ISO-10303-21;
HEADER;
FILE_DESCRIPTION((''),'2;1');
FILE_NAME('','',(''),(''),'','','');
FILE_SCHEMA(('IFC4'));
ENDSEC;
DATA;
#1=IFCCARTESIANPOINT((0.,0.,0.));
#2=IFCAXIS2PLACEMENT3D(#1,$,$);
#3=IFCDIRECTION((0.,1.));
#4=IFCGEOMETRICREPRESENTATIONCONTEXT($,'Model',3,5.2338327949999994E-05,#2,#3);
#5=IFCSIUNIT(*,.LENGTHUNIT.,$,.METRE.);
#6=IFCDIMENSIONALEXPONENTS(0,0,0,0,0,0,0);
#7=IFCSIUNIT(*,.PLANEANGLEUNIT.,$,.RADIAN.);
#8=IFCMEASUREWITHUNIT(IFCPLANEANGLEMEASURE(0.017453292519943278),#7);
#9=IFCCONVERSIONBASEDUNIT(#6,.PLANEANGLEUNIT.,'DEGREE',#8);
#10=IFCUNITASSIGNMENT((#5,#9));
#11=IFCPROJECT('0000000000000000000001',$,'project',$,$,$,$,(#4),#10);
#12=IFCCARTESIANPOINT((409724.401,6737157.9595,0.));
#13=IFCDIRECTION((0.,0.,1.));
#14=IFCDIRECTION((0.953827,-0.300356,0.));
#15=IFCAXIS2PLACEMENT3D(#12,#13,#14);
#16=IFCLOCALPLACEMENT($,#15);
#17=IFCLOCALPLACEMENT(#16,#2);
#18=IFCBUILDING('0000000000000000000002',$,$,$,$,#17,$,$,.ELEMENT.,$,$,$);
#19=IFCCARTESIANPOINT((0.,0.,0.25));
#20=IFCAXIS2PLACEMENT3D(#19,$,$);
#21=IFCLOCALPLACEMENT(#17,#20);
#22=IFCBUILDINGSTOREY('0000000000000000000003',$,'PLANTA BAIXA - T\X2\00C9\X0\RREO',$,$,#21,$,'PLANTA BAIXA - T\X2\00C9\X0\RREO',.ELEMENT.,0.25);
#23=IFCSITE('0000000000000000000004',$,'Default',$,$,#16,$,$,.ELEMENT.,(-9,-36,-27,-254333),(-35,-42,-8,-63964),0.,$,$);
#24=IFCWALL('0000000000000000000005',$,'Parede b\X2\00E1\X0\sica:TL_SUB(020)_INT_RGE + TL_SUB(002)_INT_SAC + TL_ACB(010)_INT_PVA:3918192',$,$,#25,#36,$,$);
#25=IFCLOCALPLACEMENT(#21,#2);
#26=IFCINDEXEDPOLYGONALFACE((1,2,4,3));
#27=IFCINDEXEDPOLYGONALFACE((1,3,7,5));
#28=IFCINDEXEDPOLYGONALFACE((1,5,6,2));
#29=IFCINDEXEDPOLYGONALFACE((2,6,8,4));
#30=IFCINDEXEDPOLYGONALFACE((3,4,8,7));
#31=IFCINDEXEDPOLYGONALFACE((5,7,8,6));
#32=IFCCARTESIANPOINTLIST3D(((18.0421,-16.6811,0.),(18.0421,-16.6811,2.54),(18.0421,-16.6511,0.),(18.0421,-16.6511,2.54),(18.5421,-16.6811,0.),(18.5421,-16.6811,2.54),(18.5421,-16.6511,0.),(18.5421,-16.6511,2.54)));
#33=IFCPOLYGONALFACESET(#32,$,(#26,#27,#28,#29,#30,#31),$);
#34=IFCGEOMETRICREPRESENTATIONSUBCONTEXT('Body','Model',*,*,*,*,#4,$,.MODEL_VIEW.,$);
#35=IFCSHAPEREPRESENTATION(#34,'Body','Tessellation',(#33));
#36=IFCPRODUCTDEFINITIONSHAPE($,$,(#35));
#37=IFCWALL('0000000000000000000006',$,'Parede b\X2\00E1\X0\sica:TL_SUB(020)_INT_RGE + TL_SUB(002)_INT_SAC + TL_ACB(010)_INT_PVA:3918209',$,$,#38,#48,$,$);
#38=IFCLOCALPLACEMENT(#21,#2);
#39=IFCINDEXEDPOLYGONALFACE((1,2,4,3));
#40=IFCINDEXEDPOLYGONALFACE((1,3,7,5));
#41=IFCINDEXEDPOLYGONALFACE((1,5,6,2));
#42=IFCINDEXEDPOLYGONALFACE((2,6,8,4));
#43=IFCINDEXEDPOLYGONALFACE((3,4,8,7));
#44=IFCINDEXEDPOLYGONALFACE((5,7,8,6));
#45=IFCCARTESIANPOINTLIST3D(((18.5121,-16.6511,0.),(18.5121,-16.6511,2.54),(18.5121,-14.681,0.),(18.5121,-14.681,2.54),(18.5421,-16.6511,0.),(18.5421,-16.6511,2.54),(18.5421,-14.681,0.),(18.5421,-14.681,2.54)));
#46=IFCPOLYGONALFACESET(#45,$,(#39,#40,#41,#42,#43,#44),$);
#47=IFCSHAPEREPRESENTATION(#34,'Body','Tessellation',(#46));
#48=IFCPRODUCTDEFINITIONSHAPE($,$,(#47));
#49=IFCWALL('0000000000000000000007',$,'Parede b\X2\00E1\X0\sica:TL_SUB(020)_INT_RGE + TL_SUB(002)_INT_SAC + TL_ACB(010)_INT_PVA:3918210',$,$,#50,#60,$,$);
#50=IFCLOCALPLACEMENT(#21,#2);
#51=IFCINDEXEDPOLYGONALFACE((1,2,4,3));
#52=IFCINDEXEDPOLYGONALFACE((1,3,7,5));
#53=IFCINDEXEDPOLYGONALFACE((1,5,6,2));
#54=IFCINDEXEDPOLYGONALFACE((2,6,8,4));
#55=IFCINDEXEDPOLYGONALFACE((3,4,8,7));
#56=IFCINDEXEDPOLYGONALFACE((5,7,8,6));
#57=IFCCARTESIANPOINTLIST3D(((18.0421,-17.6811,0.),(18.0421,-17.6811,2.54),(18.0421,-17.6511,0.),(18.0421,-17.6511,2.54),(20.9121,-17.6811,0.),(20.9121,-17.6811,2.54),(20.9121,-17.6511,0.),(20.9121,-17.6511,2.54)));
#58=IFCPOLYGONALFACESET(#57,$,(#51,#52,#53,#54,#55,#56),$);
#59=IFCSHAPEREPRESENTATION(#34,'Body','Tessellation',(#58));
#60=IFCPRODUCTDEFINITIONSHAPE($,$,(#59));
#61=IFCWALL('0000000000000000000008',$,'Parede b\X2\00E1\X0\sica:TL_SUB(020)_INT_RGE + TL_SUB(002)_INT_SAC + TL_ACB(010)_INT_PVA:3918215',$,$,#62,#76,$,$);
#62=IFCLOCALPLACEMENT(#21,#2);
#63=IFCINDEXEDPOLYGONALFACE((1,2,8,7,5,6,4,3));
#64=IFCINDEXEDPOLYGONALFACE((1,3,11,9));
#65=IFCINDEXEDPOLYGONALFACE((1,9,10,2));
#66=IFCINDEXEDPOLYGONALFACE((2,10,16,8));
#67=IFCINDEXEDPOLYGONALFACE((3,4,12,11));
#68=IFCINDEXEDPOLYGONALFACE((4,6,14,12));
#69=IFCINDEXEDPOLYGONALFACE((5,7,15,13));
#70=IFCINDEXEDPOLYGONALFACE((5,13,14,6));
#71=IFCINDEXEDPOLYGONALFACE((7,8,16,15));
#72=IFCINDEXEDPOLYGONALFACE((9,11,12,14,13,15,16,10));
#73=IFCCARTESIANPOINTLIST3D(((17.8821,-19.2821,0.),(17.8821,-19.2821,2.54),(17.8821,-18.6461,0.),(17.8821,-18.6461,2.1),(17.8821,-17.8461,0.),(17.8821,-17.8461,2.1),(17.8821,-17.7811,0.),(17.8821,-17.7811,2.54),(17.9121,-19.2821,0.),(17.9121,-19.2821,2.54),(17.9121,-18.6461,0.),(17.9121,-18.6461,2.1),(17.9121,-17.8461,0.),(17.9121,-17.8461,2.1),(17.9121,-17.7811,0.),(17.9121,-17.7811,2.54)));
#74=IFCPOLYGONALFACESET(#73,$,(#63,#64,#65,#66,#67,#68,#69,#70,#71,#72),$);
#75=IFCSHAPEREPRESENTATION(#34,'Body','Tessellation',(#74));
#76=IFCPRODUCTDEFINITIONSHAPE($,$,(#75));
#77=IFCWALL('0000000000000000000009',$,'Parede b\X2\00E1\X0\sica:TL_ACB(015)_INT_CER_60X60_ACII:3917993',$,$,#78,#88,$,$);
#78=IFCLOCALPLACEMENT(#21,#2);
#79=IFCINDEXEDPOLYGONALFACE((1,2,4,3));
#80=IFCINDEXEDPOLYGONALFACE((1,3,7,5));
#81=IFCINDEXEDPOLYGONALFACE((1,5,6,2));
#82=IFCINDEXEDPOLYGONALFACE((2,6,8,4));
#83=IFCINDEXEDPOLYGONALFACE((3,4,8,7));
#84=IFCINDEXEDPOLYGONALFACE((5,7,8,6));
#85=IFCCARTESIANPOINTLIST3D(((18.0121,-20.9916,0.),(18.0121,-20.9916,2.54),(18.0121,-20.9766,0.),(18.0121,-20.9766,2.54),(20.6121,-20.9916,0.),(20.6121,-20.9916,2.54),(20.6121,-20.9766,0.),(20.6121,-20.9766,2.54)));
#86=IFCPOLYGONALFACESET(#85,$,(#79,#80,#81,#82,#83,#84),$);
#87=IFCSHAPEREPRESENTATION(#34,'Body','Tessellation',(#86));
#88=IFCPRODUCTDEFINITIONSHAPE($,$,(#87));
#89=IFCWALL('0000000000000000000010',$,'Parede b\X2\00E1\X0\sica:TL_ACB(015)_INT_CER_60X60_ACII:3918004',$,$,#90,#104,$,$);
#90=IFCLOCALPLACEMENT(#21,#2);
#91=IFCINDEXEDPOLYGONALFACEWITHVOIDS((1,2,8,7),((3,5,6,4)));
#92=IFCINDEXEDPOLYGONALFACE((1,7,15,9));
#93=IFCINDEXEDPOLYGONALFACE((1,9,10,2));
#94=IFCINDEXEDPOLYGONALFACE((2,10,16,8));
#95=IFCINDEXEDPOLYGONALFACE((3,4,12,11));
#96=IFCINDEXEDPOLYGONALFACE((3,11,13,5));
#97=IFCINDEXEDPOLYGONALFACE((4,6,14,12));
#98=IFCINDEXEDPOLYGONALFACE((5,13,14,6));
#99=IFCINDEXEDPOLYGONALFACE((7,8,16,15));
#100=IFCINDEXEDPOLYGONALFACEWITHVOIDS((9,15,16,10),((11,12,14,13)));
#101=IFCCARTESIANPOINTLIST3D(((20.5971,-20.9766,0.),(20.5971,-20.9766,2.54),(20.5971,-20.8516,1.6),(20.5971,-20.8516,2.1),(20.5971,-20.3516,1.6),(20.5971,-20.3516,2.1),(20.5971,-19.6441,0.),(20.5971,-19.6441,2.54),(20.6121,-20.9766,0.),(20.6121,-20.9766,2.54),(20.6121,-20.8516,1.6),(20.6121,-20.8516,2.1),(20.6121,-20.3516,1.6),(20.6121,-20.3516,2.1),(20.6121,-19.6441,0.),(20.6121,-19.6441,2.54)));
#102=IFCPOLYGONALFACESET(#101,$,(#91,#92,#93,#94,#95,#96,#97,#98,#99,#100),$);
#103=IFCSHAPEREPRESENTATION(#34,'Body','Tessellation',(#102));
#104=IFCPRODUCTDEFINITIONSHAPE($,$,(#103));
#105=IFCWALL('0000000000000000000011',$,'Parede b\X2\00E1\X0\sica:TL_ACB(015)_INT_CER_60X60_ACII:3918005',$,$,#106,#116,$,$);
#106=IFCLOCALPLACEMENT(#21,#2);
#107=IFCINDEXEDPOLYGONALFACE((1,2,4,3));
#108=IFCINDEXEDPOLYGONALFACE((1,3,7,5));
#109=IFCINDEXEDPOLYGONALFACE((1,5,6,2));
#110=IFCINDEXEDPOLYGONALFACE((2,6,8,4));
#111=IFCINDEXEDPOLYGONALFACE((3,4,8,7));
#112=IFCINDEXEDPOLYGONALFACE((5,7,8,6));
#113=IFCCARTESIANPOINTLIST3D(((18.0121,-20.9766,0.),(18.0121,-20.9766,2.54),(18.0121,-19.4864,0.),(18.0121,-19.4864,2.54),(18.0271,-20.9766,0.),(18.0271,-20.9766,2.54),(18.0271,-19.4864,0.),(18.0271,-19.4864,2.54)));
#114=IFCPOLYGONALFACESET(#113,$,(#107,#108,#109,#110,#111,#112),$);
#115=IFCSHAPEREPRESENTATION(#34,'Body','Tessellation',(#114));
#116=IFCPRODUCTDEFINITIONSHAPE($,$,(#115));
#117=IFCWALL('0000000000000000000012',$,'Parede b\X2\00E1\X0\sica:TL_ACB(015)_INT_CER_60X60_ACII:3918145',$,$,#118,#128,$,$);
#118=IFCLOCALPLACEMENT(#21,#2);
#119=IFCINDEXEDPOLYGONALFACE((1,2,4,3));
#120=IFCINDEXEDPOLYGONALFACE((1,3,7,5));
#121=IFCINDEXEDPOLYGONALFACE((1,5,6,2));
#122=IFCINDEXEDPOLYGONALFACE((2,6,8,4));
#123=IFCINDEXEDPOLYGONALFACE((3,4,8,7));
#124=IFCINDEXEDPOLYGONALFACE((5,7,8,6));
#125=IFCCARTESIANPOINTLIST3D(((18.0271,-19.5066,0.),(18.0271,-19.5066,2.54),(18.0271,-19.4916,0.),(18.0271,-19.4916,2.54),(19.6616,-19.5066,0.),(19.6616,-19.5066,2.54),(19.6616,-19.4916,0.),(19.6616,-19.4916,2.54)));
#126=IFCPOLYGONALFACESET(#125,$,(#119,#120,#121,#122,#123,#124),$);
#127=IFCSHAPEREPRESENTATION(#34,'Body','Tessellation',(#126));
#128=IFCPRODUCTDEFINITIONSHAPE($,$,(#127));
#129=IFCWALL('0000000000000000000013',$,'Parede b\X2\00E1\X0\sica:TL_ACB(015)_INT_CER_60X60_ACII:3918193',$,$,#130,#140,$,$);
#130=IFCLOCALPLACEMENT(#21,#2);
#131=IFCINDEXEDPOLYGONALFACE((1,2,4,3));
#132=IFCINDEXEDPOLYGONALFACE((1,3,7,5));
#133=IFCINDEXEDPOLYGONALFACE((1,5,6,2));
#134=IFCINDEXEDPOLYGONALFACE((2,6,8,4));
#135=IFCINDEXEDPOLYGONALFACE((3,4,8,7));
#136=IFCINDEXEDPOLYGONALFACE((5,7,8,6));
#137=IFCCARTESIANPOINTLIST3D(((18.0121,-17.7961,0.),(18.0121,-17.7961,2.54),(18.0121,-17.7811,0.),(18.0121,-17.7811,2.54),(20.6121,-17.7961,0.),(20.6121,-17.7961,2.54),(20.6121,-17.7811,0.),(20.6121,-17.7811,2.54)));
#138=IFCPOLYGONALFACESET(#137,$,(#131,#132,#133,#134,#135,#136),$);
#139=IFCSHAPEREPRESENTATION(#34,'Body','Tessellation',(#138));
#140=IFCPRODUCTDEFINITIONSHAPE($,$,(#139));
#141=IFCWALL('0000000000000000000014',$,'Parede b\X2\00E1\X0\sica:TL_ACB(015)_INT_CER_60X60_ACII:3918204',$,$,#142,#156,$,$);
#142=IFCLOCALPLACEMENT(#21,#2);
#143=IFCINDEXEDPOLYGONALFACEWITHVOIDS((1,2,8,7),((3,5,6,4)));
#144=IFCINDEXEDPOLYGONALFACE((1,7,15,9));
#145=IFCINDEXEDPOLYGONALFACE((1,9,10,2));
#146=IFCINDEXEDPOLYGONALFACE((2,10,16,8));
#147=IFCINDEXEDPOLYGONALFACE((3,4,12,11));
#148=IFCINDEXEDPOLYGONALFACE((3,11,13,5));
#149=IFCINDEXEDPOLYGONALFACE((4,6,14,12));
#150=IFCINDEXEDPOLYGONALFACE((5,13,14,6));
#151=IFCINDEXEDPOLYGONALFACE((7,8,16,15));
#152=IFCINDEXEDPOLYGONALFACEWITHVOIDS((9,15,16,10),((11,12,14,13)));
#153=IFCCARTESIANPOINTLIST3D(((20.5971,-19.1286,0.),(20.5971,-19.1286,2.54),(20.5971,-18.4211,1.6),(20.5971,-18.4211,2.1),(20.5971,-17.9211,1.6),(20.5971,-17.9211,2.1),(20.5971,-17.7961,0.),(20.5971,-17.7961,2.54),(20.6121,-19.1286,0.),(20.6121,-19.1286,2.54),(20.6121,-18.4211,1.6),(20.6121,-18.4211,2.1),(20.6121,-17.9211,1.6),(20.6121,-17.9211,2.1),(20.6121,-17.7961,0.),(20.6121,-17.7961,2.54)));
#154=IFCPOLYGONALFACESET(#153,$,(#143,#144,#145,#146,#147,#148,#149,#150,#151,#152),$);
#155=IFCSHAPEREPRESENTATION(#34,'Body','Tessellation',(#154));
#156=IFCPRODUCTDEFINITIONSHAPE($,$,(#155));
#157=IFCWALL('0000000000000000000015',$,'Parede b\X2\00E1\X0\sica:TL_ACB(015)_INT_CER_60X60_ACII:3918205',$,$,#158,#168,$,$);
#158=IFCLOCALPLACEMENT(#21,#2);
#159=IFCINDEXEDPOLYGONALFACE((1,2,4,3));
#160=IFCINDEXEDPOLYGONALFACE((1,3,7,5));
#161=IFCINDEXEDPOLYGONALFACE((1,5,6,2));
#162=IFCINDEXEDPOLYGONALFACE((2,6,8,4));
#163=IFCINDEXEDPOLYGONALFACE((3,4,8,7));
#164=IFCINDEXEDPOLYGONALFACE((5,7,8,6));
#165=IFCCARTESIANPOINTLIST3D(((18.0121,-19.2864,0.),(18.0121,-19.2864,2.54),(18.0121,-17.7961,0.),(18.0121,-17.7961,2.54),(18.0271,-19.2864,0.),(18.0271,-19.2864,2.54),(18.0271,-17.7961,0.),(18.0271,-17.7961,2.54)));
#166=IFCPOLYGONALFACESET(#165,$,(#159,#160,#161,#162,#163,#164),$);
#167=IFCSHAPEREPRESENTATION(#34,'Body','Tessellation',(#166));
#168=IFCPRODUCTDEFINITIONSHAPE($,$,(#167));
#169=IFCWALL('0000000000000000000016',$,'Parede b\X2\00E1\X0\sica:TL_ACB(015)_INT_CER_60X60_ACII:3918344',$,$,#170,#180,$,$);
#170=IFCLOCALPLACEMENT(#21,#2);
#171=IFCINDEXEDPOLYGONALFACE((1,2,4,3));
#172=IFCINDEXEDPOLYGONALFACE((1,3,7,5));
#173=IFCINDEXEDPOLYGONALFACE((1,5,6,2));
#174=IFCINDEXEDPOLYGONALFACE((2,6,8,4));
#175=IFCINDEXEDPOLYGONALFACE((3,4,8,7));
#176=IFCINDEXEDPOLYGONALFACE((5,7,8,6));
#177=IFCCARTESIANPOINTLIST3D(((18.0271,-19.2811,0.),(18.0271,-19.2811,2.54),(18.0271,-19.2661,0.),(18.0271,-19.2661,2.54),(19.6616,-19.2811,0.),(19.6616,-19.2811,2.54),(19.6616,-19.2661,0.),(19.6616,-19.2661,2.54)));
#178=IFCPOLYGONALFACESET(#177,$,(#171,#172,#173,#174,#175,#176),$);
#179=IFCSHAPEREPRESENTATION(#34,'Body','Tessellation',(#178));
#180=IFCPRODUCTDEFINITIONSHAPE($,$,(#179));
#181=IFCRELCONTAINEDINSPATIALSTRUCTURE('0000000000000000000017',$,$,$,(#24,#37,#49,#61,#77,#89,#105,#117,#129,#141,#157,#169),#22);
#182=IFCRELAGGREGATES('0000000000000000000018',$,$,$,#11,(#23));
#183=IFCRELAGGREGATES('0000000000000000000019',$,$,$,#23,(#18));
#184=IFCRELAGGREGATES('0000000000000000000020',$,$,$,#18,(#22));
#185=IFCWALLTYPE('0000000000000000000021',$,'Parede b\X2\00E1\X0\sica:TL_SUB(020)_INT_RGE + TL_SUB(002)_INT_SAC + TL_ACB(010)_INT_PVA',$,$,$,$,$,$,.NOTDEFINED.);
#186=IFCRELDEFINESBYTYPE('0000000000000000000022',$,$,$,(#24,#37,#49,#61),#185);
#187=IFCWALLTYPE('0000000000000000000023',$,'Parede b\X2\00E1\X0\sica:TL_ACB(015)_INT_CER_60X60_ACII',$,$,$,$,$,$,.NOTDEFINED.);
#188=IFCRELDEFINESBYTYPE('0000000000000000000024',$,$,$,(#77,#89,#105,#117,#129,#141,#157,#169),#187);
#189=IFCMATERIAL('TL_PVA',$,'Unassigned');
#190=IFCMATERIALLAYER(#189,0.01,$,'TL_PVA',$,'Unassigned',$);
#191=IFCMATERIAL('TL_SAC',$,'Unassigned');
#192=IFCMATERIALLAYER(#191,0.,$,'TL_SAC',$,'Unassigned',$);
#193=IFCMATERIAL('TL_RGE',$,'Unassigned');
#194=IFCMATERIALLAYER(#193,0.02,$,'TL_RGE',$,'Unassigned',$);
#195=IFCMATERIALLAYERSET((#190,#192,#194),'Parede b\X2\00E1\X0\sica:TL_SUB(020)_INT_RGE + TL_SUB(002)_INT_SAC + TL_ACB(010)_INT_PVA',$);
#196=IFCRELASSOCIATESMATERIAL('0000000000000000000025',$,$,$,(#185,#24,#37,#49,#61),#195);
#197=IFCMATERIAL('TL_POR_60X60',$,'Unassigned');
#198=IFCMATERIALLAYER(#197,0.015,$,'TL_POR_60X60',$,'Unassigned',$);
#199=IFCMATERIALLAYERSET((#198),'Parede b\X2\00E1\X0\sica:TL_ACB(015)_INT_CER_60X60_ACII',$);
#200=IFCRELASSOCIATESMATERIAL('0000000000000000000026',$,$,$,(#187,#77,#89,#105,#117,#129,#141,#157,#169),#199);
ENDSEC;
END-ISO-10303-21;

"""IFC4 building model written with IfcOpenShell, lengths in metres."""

from ifc_helpers import new_model, entity, si_unit, converted_unit, direction, frame, frame_2d, origin, place, context, subcontext, project, spatial, rectangle, extrude, material, layer, layer_set, layer_usage, type_object, element, save


model = new_model("IFC4")

# Units and contexts
model_context = context("Model", 3, precision=5.2338327949999994e-05, world=origin(), true_north=direction((0.0, 1.0)))
body_context = subcontext(model_context, "Body", "Model", "MODEL_VIEW")
ifc_project = project(units=[si_unit("LENGTHUNIT", "METRE"), converted_unit("PLANEANGLEUNIT", "DEGREE", entity("IfcPlaneAngleMeasure", 0.017453292519943278), si_unit("PLANEANGLEUNIT", "RADIAN"), dimensions=[0, 0, 0, 0, 0, 0, 0])], contexts=[model_context])

# Site, building, storey
site_placement = place(None, frame((409724.401, 6737157.9595, 0.0), z_axis=(0.0, 0.0, 1.0), x_axis=(0.953827, -0.300356, 0.0)))
site = spatial("IfcSite", under=ifc_project, at=site_placement, Name="Default", CompositionType="ELEMENT", RefLatitude=(-9, -36, -27, -254333), RefLongitude=(-35, -42, -8, -63964), RefElevation=0.0)
building_placement = place(site_placement, origin())
building = spatial("IfcBuilding", under=site, at=building_placement, CompositionType="ELEMENT")
storey_placement = place(building_placement, frame((0.0, 0.0, 0.25)))
storey = spatial("IfcBuildingStorey", under=building, at=storey_placement, Name="PLANTA BAIXA - TÉRREO", LongName="PLANTA BAIXA - TÉRREO", CompositionType="ELEMENT", Elevation=0.25)

# Shared definitions
ifc_material_1 = material(Name="TL_PVA", Category="Unassigned")
ifc_layer_1 = layer(ifc_material_1, 0.01, Name="TL_PVA", Category="Unassigned")
ifc_material_2 = material(Name="TL_SAC", Category="Unassigned")
ifc_layer_2 = layer(ifc_material_2, 0.0, Name="TL_SAC", Category="Unassigned")
ifc_material_3 = material(Name="TL_RGE", Category="Unassigned")
ifc_layer_3 = layer(ifc_material_3, 0.02, Name="TL_RGE", Category="Unassigned")
ifc_layer_set_1 = layer_set([ifc_layer_1, ifc_layer_2, ifc_layer_3], Name="Parede básica:TL_SUB(020)_INT_RGE + TL_SUB(002)_INT_SAC + TL_ACB(010)_INT_PVA")
wall_type_1 = type_object("IfcWallType", Name="Parede básica:TL_SUB(020)_INT_RGE + TL_SUB(002)_INT_SAC + TL_ACB(010)_INT_PVA", PredefinedType="NOTDEFINED", material=ifc_layer_set_1)

# Walls
ifc_layer_usage_1 = layer_usage(ifc_layer_set_1, "AXIS2", "NEGATIVE", 0.015)
wall_1_placement = place(storey_placement, frame((18.5421, -16.6661, 0.0), z_axis=(0.0, 0.0, 1.0), x_axis=(-1.0, 0.0, 0.0)))
element("IfcWall", 1, at=wall_1_placement, inside=storey, type_object=wall_type_1, material=ifc_layer_usage_1, Name="Parede básica:TL_SUB(020)_INT_RGE + TL_SUB(002)_INT_SAC + TL_ACB(010)_INT_PVA:3918192", context=body_context, shape_type="SweptSolid", body=[
    extrude(rectangle(XDim=0.5, YDim=0.03, at=frame_2d((0.25, 0.0), x_axis=(-1.0, 0.0))), origin(), (0.0, 0.0, 1.0), 2.54),
])
ifc_layer_usage_2 = layer_usage(ifc_layer_set_1, "AXIS2", "POSITIVE", -0.015)
wall_2_placement = place(storey_placement, frame((18.5271, -16.6511, 0.0), z_axis=(0.0, 0.0, 1.0), x_axis=(0.0, 1.0, 0.0)))
element("IfcWall", 2, at=wall_2_placement, inside=storey, type_object=wall_type_1, material=ifc_layer_usage_2, Name="Parede básica:TL_SUB(020)_INT_RGE + TL_SUB(002)_INT_SAC + TL_ACB(010)_INT_PVA:3918209", context=body_context, shape_type="SweptSolid", body=[
    extrude(rectangle(XDim=1.9701, YDim=0.03, at=frame_2d((0.9851, 0.0), x_axis=(-1.0, 0.0))), origin(), (0.0, 0.0, 1.0), 2.54),
])
ifc_layer_usage_3 = layer_usage(ifc_layer_set_1, "AXIS2", "POSITIVE", -0.015)
wall_3_placement = place(storey_placement, frame((20.9121, -17.6661, 0.0), z_axis=(0.0, 0.0, 1.0), x_axis=(-1.0, 0.0, 0.0)))
element("IfcWall", 3, at=wall_3_placement, inside=storey, type_object=wall_type_1, material=ifc_layer_usage_3, Name="Parede básica:TL_SUB(020)_INT_RGE + TL_SUB(002)_INT_SAC + TL_ACB(010)_INT_PVA:3918210", context=body_context, shape_type="SweptSolid", body=[
    extrude(rectangle(XDim=2.87, YDim=0.03, at=frame_2d((1.435, 0.0), x_axis=(-1.0, 0.0))), origin(), (0.0, 0.0, 1.0), 2.54),
])

# Wall, opening
ifc_layer_usage_4 = layer_usage(ifc_layer_set_1, "AXIS2", "POSITIVE", -0.015)
wall_4_placement = place(storey_placement, frame((17.8971, -17.7811, 0.0), z_axis=(0.0, 0.0, 1.0), x_axis=(0.0, -1.0, 0.0)))
wall_4 = element("IfcWall", 4, at=wall_4_placement, inside=storey, type_object=wall_type_1, material=ifc_layer_usage_4, Name="Parede básica:TL_SUB(020)_INT_RGE + TL_SUB(002)_INT_SAC + TL_ACB(010)_INT_PVA:3918215", context=body_context, shape_type="SweptSolid", body=[
    extrude(rectangle(XDim=1.501, YDim=0.03, at=frame_2d((0.7505, 0.0), x_axis=(-1.0, 0.0))), origin(), (0.0, 0.0, 1.0), 2.54),
])
opening_1_placement = place(wall_4_placement, frame((0.065, -0.015, 0.0)))
element("IfcOpeningElement", 5, at=opening_1_placement, cuts=wall_4, PredefinedType="OPENING", context=body_context, shape_type="SweptSolid", body=[
    extrude(rectangle(XDim=2.1, YDim=0.8, at=frame_2d((1.05, 0.4), x_axis=(1.0, 0.0))), frame((0.0, 0.0, 0.0), z_axis=(0.0, 1.0, 0.0), x_axis=(0.0, 0.0, 1.0)), (0.0, 0.0, 1.0), 0.03),
])

# Wall
ifc_material_4 = material(Name="TL_POR_60X60", Category="Unassigned")
ifc_layer_4 = layer(ifc_material_4, 0.015, Name="TL_POR_60X60", Category="Unassigned")
ifc_layer_set_2 = layer_set([ifc_layer_4], Name="Parede básica:TL_ACB(015)_INT_CER_60X60_ACII")
ifc_layer_usage_5 = layer_usage(ifc_layer_set_2, "AXIS2", "POSITIVE", -0.0075)
wall_type_2 = type_object("IfcWallType", Name="Parede básica:TL_ACB(015)_INT_CER_60X60_ACII", PredefinedType="NOTDEFINED", material=ifc_layer_set_2)
wall_5_placement = place(storey_placement, frame((20.6121, -20.9841, 0.0), z_axis=(0.0, 0.0, 1.0), x_axis=(-1.0, 0.0, 0.0)))
element("IfcWall", 6, at=wall_5_placement, inside=storey, type_object=wall_type_2, material=ifc_layer_usage_5, Name="Parede básica:TL_ACB(015)_INT_CER_60X60_ACII:3917993", context=body_context, shape_type="SweptSolid", body=[
    extrude(rectangle(XDim=2.6, YDim=0.015, at=frame_2d((1.3, 0.0), x_axis=(-1.0, 0.0))), origin(), (0.0, 0.0, 1.0), 2.54),
])

# Wall, opening
ifc_layer_usage_6 = layer_usage(ifc_layer_set_2, "AXIS2", "NEGATIVE", 0.0075)
wall_6_placement = place(storey_placement, frame((20.6046, -20.9766, 0.0), z_axis=(0.0, 0.0, 1.0), x_axis=(0.0, 1.0, 0.0)))
wall_6 = element("IfcWall", 7, at=wall_6_placement, inside=storey, type_object=wall_type_2, material=ifc_layer_usage_6, Name="Parede básica:TL_ACB(015)_INT_CER_60X60_ACII:3918004", context=body_context, shape_type="SweptSolid", body=[
    extrude(rectangle(XDim=1.3325, YDim=0.015, at=frame_2d((0.6662, 0.0), x_axis=(-1.0, 0.0))), origin(), (0.0, 0.0, 1.0), 2.54),
])
opening_2_placement = place(wall_6_placement, frame((20.9766, 20.6046, 1.6)))
element("IfcOpeningElement", 8, at=opening_2_placement, cuts=wall_6, PredefinedType="OPENING", context=body_context, shape_type="SweptSolid", body=[
    extrude(rectangle(XDim=0.5, YDim=0.5, at=frame_2d((0.0, 0.0), x_axis=(1.0, 0.0))), frame((-20.6016, -22.2361, 0.25), z_axis=(0.0, 1.0, 0.0), x_axis=(0.0, 0.0, 1.0)), (0.0, 0.0, 1.0), 3.048),
])

# Walls
ifc_layer_usage_7 = layer_usage(ifc_layer_set_2, "AXIS2", "NEGATIVE", 0.0075)
wall_7_placement = place(storey_placement, frame((18.0196, -19.4864, 0.0), z_axis=(0.0, 0.0, 1.0), x_axis=(0.0, -1.0, 0.0)))
element("IfcWall", 9, at=wall_7_placement, inside=storey, type_object=wall_type_2, material=ifc_layer_usage_7, Name="Parede básica:TL_ACB(015)_INT_CER_60X60_ACII:3918005", context=body_context, shape_type="SweptSolid", body=[
    extrude(rectangle(XDim=1.4902, YDim=0.015, at=frame_2d((0.7451, 0.0), x_axis=(-1.0, 0.0))), origin(), (0.0, 0.0, 1.0), 2.54),
])
ifc_layer_usage_8 = layer_usage(ifc_layer_set_2, "AXIS2", "POSITIVE", -0.0075)
wall_8_placement = place(storey_placement, frame((18.0271, -19.4991, 0.0)))
element("IfcWall", 10, at=wall_8_placement, inside=storey, type_object=wall_type_2, material=ifc_layer_usage_8, Name="Parede básica:TL_ACB(015)_INT_CER_60X60_ACII:3918145", context=body_context, shape_type="SweptSolid", body=[
    extrude(rectangle(XDim=1.6345, YDim=0.015, at=frame_2d((0.8172, 0.0), x_axis=(-1.0, 0.0))), origin(), (0.0, 0.0, 1.0), 2.54),
])
ifc_layer_usage_9 = layer_usage(ifc_layer_set_2, "AXIS2", "NEGATIVE", 0.0075)
wall_9_placement = place(storey_placement, frame((20.6121, -17.7886, 0.0), z_axis=(0.0, 0.0, 1.0), x_axis=(-1.0, 0.0, 0.0)))
element("IfcWall", 11, at=wall_9_placement, inside=storey, type_object=wall_type_2, material=ifc_layer_usage_9, Name="Parede básica:TL_ACB(015)_INT_CER_60X60_ACII:3918193", context=body_context, shape_type="SweptSolid", body=[
    extrude(rectangle(XDim=2.6, YDim=0.015, at=frame_2d((1.3, 0.0), x_axis=(-1.0, 0.0))), origin(), (0.0, 0.0, 1.0), 2.54),
])

# Wall, opening
ifc_layer_usage_10 = layer_usage(ifc_layer_set_2, "AXIS2", "POSITIVE", -0.0075)
wall_10_placement = place(storey_placement, frame((20.6046, -17.7961, 0.0), z_axis=(0.0, 0.0, 1.0), x_axis=(0.0, -1.0, 0.0)))
wall_10 = element("IfcWall", 12, at=wall_10_placement, inside=storey, type_object=wall_type_2, material=ifc_layer_usage_10, Name="Parede básica:TL_ACB(015)_INT_CER_60X60_ACII:3918204", context=body_context, shape_type="SweptSolid", body=[
    extrude(rectangle(XDim=1.3325, YDim=0.015, at=frame_2d((0.6662, 0.0), x_axis=(-1.0, 0.0))), origin(), (0.0, 0.0, 1.0), 2.54),
])
opening_3_placement = place(wall_10_placement, frame((-17.7961, -20.6046, 1.6)))
element("IfcOpeningElement", 13, at=opening_3_placement, cuts=wall_10, PredefinedType="OPENING", context=body_context, shape_type="SweptSolid", body=[
    extrude(rectangle(XDim=0.5, YDim=0.5, at=frame_2d((0.0, 0.0), x_axis=(1.0, 0.0))), frame((18.1711, 19.1881, 0.25), z_axis=(0.0, 1.0, 0.0), x_axis=(0.0, 0.0, 1.0)), (0.0, 0.0, 1.0), 3.048),
])

# Walls
ifc_layer_usage_11 = layer_usage(ifc_layer_set_2, "AXIS2", "POSITIVE", -0.0075)
wall_11_placement = place(storey_placement, frame((18.0196, -19.2864, 0.0), z_axis=(0.0, 0.0, 1.0), x_axis=(0.0, 1.0, 0.0)))
element("IfcWall", 14, at=wall_11_placement, inside=storey, type_object=wall_type_2, material=ifc_layer_usage_11, Name="Parede básica:TL_ACB(015)_INT_CER_60X60_ACII:3918205", context=body_context, shape_type="SweptSolid", body=[
    extrude(rectangle(XDim=1.4902, YDim=0.015, at=frame_2d((0.7451, 0.0), x_axis=(-1.0, 0.0))), origin(), (0.0, 0.0, 1.0), 2.54),
])
ifc_layer_usage_12 = layer_usage(ifc_layer_set_2, "AXIS2", "NEGATIVE", 0.0075)
wall_12_placement = place(storey_placement, frame((18.0271, -19.2736, 0.0)))
element("IfcWall", 15, at=wall_12_placement, inside=storey, type_object=wall_type_2, material=ifc_layer_usage_12, Name="Parede básica:TL_ACB(015)_INT_CER_60X60_ACII:3918344", context=body_context, shape_type="SweptSolid", body=[
    extrude(rectangle(XDim=1.6345, YDim=0.015, at=frame_2d((0.8172, 0.0), x_axis=(-1.0, 0.0))), origin(), (0.0, 0.0, 1.0), 2.54),
])

save(model, "model.ifc")
